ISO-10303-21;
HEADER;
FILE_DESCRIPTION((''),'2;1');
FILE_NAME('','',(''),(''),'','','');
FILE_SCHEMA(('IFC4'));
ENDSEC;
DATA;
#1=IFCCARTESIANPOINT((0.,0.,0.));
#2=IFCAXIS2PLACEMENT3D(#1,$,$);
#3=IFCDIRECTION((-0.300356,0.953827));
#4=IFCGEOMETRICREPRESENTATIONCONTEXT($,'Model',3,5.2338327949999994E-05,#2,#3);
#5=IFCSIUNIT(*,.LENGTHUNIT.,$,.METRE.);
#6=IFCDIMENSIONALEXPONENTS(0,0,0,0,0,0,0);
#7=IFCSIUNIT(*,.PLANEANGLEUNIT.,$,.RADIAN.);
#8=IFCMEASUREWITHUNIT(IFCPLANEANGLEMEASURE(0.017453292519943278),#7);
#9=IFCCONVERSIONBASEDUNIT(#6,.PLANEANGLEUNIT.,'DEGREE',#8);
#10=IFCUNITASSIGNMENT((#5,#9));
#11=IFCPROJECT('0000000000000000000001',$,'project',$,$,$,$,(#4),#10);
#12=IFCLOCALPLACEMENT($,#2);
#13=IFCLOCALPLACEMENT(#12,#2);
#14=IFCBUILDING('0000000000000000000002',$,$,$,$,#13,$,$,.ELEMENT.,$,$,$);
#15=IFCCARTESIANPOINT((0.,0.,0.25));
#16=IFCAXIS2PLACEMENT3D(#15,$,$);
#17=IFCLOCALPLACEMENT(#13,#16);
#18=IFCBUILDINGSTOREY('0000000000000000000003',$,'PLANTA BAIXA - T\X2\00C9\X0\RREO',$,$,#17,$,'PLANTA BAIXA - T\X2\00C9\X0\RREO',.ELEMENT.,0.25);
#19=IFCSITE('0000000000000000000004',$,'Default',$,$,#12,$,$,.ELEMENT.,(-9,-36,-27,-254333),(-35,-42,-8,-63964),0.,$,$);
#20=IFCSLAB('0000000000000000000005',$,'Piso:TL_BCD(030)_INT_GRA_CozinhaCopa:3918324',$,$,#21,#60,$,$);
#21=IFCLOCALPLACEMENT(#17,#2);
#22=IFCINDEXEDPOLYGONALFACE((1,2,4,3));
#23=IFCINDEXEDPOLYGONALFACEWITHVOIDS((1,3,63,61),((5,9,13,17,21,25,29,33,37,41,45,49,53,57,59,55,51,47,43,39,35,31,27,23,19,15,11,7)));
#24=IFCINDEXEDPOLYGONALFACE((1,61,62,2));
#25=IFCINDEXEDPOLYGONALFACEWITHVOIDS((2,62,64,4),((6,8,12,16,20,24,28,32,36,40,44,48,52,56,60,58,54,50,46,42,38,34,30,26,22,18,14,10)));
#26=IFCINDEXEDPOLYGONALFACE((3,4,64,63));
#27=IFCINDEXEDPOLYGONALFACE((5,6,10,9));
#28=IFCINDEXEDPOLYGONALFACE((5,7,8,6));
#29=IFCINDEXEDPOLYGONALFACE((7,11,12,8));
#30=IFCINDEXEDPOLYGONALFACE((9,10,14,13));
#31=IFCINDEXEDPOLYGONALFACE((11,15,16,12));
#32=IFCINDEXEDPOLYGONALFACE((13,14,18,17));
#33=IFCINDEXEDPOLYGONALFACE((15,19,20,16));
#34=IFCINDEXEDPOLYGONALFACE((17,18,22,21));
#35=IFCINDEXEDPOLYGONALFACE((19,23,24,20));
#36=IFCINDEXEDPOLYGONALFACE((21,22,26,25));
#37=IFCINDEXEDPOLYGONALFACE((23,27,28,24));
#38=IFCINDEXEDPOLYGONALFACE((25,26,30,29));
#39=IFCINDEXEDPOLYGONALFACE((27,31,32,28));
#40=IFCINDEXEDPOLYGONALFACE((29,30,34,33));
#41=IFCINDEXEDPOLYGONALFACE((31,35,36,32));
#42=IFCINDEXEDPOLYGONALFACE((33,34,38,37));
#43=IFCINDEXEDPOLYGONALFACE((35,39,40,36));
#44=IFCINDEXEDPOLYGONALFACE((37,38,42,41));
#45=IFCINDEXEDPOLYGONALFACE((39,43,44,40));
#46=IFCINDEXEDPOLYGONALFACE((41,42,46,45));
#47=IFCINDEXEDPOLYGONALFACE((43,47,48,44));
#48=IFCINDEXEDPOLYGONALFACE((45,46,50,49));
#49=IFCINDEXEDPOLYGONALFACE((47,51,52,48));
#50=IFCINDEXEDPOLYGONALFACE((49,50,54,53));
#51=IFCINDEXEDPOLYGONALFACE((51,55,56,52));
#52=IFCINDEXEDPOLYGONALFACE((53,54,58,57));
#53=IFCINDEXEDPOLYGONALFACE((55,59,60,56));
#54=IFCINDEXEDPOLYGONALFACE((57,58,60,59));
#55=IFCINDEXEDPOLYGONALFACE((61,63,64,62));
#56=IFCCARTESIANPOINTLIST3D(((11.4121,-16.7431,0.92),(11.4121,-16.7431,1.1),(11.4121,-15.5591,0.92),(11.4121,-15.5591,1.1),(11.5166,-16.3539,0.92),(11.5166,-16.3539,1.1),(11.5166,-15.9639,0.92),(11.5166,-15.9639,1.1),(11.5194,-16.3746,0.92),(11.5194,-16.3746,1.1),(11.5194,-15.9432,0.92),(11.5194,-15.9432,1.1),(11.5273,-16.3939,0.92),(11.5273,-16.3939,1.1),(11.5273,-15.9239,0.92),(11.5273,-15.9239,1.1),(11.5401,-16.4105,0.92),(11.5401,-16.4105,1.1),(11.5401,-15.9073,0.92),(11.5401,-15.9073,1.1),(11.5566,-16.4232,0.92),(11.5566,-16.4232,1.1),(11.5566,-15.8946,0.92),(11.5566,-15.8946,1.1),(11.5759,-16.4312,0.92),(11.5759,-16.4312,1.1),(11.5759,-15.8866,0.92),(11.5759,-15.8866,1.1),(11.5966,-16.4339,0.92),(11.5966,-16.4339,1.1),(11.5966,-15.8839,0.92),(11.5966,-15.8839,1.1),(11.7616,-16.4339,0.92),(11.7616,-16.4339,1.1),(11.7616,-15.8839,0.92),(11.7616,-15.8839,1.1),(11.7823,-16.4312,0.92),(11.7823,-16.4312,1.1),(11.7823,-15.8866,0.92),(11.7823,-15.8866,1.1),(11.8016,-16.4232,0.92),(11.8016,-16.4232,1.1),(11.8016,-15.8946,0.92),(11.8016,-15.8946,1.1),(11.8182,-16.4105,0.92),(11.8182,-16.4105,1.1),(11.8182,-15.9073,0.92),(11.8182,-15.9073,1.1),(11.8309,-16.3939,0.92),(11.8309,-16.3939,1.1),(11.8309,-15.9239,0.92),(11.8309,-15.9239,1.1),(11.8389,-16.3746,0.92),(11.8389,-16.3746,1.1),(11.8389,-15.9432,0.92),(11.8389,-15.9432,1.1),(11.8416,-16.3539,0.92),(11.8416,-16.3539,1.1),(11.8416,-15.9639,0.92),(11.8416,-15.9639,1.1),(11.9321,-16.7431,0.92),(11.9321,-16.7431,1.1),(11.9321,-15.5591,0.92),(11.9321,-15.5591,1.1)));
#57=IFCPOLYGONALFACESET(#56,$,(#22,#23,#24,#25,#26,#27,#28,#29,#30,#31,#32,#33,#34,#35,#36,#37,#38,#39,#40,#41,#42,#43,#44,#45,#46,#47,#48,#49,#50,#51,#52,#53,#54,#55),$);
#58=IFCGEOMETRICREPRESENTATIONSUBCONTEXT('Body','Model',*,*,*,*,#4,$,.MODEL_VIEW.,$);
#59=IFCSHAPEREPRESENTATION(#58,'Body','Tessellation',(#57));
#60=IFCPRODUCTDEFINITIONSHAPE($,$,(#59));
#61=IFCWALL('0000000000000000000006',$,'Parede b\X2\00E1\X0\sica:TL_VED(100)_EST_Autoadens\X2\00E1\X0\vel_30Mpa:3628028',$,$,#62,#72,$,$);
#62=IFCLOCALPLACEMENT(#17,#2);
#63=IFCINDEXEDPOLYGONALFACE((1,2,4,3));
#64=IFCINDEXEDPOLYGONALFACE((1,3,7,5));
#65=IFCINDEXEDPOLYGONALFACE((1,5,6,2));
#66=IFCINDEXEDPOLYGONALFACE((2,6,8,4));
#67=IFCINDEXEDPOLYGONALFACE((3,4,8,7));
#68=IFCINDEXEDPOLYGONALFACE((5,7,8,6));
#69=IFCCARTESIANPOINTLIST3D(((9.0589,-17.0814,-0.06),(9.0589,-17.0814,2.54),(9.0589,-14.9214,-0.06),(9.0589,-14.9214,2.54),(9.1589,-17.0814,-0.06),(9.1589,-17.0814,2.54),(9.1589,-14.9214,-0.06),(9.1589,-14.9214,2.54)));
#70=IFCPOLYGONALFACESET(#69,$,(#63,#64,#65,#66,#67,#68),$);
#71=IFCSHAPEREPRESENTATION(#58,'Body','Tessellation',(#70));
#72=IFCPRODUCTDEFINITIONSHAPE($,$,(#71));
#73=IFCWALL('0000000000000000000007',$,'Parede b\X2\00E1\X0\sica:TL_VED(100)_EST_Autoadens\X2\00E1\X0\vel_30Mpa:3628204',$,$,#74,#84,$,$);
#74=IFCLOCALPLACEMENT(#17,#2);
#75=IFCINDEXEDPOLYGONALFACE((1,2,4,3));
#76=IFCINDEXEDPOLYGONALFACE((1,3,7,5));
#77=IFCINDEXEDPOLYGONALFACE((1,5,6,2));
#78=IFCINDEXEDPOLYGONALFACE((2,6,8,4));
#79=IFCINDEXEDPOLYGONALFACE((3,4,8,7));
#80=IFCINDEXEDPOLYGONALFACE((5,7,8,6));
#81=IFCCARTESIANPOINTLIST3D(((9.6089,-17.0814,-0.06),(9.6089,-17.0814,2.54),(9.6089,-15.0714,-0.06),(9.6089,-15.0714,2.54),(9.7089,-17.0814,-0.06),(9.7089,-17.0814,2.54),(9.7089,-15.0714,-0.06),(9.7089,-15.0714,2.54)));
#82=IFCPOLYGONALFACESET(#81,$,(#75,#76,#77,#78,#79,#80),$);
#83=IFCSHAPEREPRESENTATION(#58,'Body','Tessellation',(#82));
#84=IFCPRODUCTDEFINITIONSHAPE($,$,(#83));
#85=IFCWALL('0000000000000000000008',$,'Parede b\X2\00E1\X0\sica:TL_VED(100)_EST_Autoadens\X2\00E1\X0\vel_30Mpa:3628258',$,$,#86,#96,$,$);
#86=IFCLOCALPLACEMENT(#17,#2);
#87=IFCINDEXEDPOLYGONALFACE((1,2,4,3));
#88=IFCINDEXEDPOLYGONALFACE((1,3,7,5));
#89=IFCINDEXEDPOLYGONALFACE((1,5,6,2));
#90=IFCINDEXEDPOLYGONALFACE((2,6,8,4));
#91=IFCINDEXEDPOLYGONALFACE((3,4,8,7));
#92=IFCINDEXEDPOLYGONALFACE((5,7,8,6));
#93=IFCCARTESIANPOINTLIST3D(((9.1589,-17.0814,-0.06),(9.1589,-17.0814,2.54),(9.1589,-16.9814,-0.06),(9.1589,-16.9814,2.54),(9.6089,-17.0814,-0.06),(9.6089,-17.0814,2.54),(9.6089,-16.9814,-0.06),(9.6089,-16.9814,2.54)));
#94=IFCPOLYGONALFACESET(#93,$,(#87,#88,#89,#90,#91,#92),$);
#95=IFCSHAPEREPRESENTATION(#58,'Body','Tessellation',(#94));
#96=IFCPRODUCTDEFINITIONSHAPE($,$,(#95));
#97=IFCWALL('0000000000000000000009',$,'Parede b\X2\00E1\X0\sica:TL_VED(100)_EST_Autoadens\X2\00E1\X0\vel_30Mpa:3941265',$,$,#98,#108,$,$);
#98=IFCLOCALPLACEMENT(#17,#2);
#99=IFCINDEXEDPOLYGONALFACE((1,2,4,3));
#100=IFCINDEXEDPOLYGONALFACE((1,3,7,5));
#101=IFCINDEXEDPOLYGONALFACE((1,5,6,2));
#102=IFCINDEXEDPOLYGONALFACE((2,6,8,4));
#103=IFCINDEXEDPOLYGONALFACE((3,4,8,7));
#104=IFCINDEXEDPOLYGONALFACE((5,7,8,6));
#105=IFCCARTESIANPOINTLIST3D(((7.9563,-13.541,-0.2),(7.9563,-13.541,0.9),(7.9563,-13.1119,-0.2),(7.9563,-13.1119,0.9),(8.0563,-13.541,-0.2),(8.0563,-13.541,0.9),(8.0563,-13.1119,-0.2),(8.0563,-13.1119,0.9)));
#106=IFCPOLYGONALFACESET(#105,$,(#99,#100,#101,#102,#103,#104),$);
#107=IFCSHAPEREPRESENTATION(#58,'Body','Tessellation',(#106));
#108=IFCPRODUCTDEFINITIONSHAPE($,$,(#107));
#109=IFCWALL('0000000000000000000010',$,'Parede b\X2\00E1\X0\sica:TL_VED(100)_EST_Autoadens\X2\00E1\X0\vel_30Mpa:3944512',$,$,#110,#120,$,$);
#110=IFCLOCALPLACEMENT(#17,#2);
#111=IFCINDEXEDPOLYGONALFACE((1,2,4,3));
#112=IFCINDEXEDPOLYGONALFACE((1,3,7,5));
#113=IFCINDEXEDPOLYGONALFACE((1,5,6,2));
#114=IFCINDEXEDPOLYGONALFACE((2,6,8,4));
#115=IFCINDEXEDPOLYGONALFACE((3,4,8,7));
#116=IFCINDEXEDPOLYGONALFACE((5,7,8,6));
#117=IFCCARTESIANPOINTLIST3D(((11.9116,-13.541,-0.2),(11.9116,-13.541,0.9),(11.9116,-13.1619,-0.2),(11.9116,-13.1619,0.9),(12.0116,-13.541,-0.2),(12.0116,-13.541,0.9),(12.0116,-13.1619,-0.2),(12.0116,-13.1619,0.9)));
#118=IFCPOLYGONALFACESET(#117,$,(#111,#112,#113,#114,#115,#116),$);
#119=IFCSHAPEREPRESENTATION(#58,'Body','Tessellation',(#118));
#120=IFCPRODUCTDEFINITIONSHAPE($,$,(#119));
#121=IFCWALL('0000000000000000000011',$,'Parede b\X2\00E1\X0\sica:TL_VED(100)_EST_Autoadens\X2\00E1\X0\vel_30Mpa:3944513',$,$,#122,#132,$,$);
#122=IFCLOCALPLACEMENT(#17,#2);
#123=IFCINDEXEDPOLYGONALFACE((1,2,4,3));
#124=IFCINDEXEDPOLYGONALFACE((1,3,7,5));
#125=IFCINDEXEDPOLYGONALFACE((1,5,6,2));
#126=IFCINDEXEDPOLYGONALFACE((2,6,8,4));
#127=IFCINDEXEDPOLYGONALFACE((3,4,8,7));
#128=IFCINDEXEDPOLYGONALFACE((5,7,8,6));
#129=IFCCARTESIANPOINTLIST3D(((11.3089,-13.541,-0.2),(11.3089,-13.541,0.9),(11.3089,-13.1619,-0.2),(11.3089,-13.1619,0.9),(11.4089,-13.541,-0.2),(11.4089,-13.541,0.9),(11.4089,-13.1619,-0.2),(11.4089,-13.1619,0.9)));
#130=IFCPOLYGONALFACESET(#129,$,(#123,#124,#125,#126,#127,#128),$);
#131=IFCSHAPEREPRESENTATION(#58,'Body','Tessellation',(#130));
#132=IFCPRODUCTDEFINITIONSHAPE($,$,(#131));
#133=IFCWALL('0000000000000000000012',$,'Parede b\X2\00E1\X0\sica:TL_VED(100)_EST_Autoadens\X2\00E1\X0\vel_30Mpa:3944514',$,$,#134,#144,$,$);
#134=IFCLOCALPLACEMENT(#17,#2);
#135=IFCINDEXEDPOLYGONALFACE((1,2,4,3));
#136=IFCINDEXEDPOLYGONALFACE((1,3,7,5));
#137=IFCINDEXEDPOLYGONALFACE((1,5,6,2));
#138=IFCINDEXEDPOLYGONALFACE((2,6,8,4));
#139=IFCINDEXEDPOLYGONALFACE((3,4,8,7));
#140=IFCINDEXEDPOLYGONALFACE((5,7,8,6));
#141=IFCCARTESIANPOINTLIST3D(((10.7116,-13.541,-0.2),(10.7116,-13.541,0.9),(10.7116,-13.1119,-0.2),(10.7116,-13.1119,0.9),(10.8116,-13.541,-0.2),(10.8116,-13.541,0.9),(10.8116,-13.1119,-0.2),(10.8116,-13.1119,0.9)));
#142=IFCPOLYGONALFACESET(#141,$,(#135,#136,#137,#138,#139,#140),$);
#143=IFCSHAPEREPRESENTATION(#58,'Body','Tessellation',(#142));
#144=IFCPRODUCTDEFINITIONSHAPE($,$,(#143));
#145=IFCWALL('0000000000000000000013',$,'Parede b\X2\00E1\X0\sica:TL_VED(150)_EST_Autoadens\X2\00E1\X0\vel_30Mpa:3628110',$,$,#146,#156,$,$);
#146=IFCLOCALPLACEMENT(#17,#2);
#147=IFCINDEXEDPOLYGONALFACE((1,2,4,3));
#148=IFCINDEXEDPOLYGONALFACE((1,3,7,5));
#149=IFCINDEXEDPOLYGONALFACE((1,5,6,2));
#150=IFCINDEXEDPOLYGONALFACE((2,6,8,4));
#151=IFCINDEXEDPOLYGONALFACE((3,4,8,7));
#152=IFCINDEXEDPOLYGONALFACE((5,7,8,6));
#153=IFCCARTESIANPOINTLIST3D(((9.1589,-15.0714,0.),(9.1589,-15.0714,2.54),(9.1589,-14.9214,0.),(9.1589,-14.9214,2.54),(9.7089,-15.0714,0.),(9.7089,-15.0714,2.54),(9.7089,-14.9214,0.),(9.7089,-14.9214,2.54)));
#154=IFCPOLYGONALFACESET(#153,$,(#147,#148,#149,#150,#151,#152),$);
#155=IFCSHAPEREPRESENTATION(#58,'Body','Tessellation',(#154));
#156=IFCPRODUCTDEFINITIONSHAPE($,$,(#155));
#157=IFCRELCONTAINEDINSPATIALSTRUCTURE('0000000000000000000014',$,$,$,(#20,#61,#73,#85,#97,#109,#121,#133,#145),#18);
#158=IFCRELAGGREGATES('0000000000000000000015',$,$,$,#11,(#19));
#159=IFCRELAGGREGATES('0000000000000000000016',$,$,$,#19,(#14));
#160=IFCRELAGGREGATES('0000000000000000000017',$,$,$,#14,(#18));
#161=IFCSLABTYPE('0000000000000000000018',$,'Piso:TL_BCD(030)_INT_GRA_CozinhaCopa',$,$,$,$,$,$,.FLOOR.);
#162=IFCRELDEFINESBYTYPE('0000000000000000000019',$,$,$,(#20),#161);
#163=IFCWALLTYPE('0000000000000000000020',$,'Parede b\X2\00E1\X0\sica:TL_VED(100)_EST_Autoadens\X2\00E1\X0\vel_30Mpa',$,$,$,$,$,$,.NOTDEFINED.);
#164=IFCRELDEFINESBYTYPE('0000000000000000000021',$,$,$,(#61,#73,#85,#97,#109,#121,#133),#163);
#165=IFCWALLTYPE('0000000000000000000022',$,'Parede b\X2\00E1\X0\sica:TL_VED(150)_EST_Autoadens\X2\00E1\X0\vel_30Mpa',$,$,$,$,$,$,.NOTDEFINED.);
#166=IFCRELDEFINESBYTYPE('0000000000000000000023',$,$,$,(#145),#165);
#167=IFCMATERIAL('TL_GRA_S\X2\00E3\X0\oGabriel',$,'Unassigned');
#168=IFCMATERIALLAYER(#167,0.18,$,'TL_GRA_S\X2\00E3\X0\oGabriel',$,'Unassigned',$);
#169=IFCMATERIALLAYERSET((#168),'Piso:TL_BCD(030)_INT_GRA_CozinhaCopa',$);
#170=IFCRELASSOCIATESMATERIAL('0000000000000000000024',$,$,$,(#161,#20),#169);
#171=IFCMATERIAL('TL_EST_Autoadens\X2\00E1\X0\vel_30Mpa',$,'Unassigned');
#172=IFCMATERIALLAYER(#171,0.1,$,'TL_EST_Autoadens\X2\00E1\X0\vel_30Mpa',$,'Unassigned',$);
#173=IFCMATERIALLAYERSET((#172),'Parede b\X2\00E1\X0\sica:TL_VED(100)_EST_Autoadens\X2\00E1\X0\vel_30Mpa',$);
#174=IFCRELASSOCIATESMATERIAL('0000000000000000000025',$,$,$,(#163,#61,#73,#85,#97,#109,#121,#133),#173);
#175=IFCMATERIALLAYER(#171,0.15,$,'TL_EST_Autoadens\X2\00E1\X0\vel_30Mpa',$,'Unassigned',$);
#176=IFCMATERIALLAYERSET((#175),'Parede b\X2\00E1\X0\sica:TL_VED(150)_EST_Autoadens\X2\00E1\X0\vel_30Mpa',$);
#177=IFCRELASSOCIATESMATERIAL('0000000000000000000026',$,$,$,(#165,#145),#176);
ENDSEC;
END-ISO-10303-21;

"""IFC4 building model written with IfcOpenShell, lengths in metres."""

from ifc_helpers import new_model, entity, si_unit, converted_unit, direction, frame, frame_2d, origin, place, context, subcontext, project, spatial, polyline, circle_curve, parameter, trimmed, segment, composite_curve, rectangle, outline, extrude, clip, bounded_halfspace, material, layer, layer_set, layer_usage, type_object, element, save


model = new_model("IFC4")

# Units and contexts
model_context = context("Model", 3, precision=5.2338327949999994e-05, world=origin(), true_north=direction((-0.300356, 0.953827)))
body_context = subcontext(model_context, "Body", "Model", "MODEL_VIEW")
ifc_project = project(units=[si_unit("LENGTHUNIT", "METRE"), converted_unit("PLANEANGLEUNIT", "DEGREE", entity("IfcPlaneAngleMeasure", 0.017453292519943278), si_unit("PLANEANGLEUNIT", "RADIAN"), dimensions=[0, 0, 0, 0, 0, 0, 0])], contexts=[model_context])

# Site, building, storey
site_placement = place(None, origin())
site = spatial("IfcSite", under=ifc_project, at=site_placement, Name="Default", CompositionType="ELEMENT", RefLatitude=(-9, -36, -27, -254333), RefLongitude=(-35, -42, -8, -63964), RefElevation=0.0)
building_placement = place(site_placement, origin())
building = spatial("IfcBuilding", under=site, at=building_placement, CompositionType="ELEMENT")
storey_placement = place(building_placement, frame((0.0, 0.0, 0.25)))
storey = spatial("IfcBuildingStorey", under=building, at=storey_placement, Name="PLANTA BAIXA - TÉRREO", LongName="PLANTA BAIXA - TÉRREO", CompositionType="ELEMENT", Elevation=0.25)

# Slab, opening
ifc_material_1 = material(Name="TL_GRA_SãoGabriel", Category="Unassigned")
ifc_layer_1 = layer(ifc_material_1, 0.18, Name="TL_GRA_SãoGabriel", Category="Unassigned")
ifc_layer_set_1 = layer_set([ifc_layer_1], Name="Piso:TL_BCD(030)_INT_GRA_CozinhaCopa")
ifc_layer_usage_1 = layer_usage(ifc_layer_set_1, "AXIS3", "POSITIVE", 0.0)
slab_type_1 = type_object("IfcSlabType", Name="Piso:TL_BCD(030)_INT_GRA_CozinhaCopa", PredefinedType="FLOOR", material=ifc_layer_set_1)
slab_1_placement = place(storey_placement, frame((11.4121, -16.7431, 0.92)))
slab_1 = element("IfcSlab", 1, at=slab_1_placement, inside=storey, type_object=slab_type_1, material=ifc_layer_usage_1, Name="Piso:TL_BCD(030)_INT_GRA_CozinhaCopa:3918324", context=body_context, shape_type="SweptSolid", body=[
    extrude(rectangle(XDim=0.52, YDim=1.184, at=frame_2d((0.0, 0.0), x_axis=(-1.0, 0.0))), frame((0.26, 0.592, 0.18), z_axis=(0.0, 0.0, -1.0), x_axis=(-1.0, 0.0, 0.0)), (0.0, 0.0, 1.0), 0.18),
])
opening_1_placement = place(slab_1_placement, frame((-11.4121, 16.7431, 0.18)))
element("IfcOpeningElement", 2, at=opening_1_placement, cuts=slab_1, PredefinedType="OPENING", context=body_context, shape_type="SweptSolid", body=[
    extrude(outline(composite_curve([segment(trimmed(circle_curve(frame_2d((0.195, -0.0825), x_axis=(1.0, 0.0)), 0.08), [parameter(270.0)], [parameter(0.0)], True, "PARAMETER"), True, "CONTINUOUS"), segment(polyline([(0.275, -0.0825), (0.275, 0.0825)]), True, "CONTINUOUS"), segment(trimmed(circle_curve(frame_2d((0.195, 0.0825), x_axis=(1.0, 0.0)), 0.08), [parameter(0.0)], [parameter(90.0)], True, "PARAMETER"), True, "CONTINUOUS"), segment(polyline([(0.195, 0.1625), (-0.195, 0.1625)]), True, "CONTINUOUS"), segment(trimmed(circle_curve(frame_2d((-0.195, 0.0825), x_axis=(1.0, 0.0)), 0.08), [parameter(90.0)], [parameter(180.0)], True, "PARAMETER"), True, "CONTINUOUS"), segment(polyline([(-0.275, 0.0825), (-0.275, -0.0825)]), True, "CONTINUOUS"), segment(trimmed(circle_curve(frame_2d((-0.195, -0.0825), x_axis=(1.0, 0.0)), 0.08), [parameter(180.0)], [parameter(270.0)], True, "PARAMETER"), True, "CONTINUOUS"), segment(polyline([(-0.195, -0.1625), (0.195, -0.1625)]), True, "CONTINUOUS")], self_intersect=False)), frame((11.6791, -16.1589, -0.21), z_axis=(0.0, 0.0, 1.0), x_axis=(0.0, -1.0, 0.0)), (0.0, 0.0, 1.0), 0.21),
])

# Walls
ifc_material_2 = material(Name="TL_EST_Autoadensável_30Mpa", Category="Unassigned")
ifc_layer_2 = layer(ifc_material_2, 0.1, Name="TL_EST_Autoadensável_30Mpa", Category="Unassigned")
ifc_layer_set_2 = layer_set([ifc_layer_2], Name="Parede básica:TL_VED(100)_EST_Autoadensável_30Mpa")
ifc_layer_usage_2 = layer_usage(ifc_layer_set_2, "AXIS2", "NEGATIVE", 0.05)
wall_type_1 = type_object("IfcWallType", Name="Parede básica:TL_VED(100)_EST_Autoadensável_30Mpa", PredefinedType="NOTDEFINED", material=ifc_layer_set_2)
wall_1_placement = place(storey_placement, frame((9.1089, -17.0814, -0.06), z_axis=(0.0, 0.0, 1.0), x_axis=(0.0, 1.0, 0.0)))
element("IfcWall", 3, at=wall_1_placement, inside=storey, type_object=wall_type_1, material=ifc_layer_usage_2, Name="Parede básica:TL_VED(100)_EST_Autoadensável_30Mpa:3628028", context=body_context, shape_type="SweptSolid", body=[
    extrude(rectangle(XDim=2.16, YDim=0.1, at=frame_2d((1.08, 0.0), x_axis=(-1.0, 0.0))), origin(), (0.0, 0.0, 1.0), 2.6),
])
ifc_layer_usage_3 = layer_usage(ifc_layer_set_2, "AXIS2", "NEGATIVE", 0.05)
wall_2_placement = place(storey_placement, frame((9.6589, -15.0714, -0.06), z_axis=(0.0, 0.0, 1.0), x_axis=(0.0, -1.0, 0.0)))
element("IfcWall", 4, at=wall_2_placement, inside=storey, type_object=wall_type_1, material=ifc_layer_usage_3, Name="Parede básica:TL_VED(100)_EST_Autoadensável_30Mpa:3628204", context=body_context, shape_type="SweptSolid", body=[
    extrude(rectangle(XDim=2.01, YDim=0.1, at=frame_2d((1.005, 0.0), x_axis=(-1.0, 0.0))), origin(), (0.0, 0.0, 1.0), 2.6),
])
ifc_layer_usage_4 = layer_usage(ifc_layer_set_2, "AXIS2", "NEGATIVE", 0.05)
wall_3_placement = place(storey_placement, frame((9.6089, -17.0314, -0.06), z_axis=(0.0, 0.0, 1.0), x_axis=(-1.0, 0.0, 0.0)))
element("IfcWall", 5, at=wall_3_placement, inside=storey, type_object=wall_type_1, material=ifc_layer_usage_4, Name="Parede básica:TL_VED(100)_EST_Autoadensável_30Mpa:3628258", context=body_context, shape_type="SweptSolid", body=[
    extrude(rectangle(XDim=0.45, YDim=0.1, at=frame_2d((0.225, 0.0), x_axis=(-1.0, 0.0))), origin(), (0.0, 0.0, 1.0), 2.6),
])
ifc_layer_usage_5 = layer_usage(ifc_layer_set_2, "AXIS2", "NEGATIVE", 0.05)
wall_4_placement = place(storey_placement, frame((8.0063, -13.1119, -0.2), z_axis=(0.0, 0.0, 1.0), x_axis=(0.0, -1.0, 0.0)))
element("IfcWall", 6, at=wall_4_placement, inside=storey, type_object=wall_type_1, material=ifc_layer_usage_5, Name="Parede básica:TL_VED(100)_EST_Autoadensável_30Mpa:3941265", context=body_context, shape_type="Clipping", body=[
    clip(extrude(rectangle(XDim=0.4291, YDim=0.1, at=frame_2d((0.2145, 0.0), x_axis=(-1.0, 0.0))), origin(), (0.0, 0.0, 1.0), 1.1), bounded_halfspace(frame((0.0, -0.05, 1.1), z_axis=(0.0, 0.0, -1.0), x_axis=(1.0, 0.0, 0.0)), True, frame((0.0, -0.05, 1.1)), polyline([(0.0, 0.0), (0.05, 0.0), (0.4291, 0.0), (0.4291, 0.1), (0.0, 0.1), (0.0, 0.0)]))),
])
ifc_layer_usage_6 = layer_usage(ifc_layer_set_2, "AXIS2", "POSITIVE", -0.05)
wall_5_placement = place(storey_placement, frame((11.9616, -13.1619, -0.2), z_axis=(0.0, 0.0, 1.0), x_axis=(0.0, -1.0, 0.0)))
element("IfcWall", 7, at=wall_5_placement, inside=storey, type_object=wall_type_1, material=ifc_layer_usage_6, Name="Parede básica:TL_VED(100)_EST_Autoadensável_30Mpa:3944512", context=body_context, shape_type="Clipping", body=[
    clip(extrude(rectangle(XDim=0.3791, YDim=0.1, at=frame_2d((0.1895, 0.0), x_axis=(-1.0, 0.0))), origin(), (0.0, 0.0, 1.0), 1.1), bounded_halfspace(frame((0.0, -0.05, 1.1), z_axis=(0.0, 0.0, -1.0), x_axis=(0.0, 1.0, 0.0)), True, frame((0.0, -0.05, 1.1)), polyline([(0.0, 0.0), (0.3791, 0.0), (0.3791, 0.1), (0.0, 0.1), (0.0, 0.0)]))),
])
ifc_layer_usage_7 = layer_usage(ifc_layer_set_2, "AXIS2", "POSITIVE", -0.05)
wall_6_placement = place(storey_placement, frame((11.3589, -13.1619, -0.2), z_axis=(0.0, 0.0, 1.0), x_axis=(0.0, -1.0, 0.0)))
element("IfcWall", 8, at=wall_6_placement, inside=storey, type_object=wall_type_1, material=ifc_layer_usage_7, Name="Parede básica:TL_VED(100)_EST_Autoadensável_30Mpa:3944513", context=body_context, shape_type="Clipping", body=[
    clip(extrude(rectangle(XDim=0.3791, YDim=0.1, at=frame_2d((0.1895, 0.0), x_axis=(-1.0, 0.0))), origin(), (0.0, 0.0, 1.0), 1.1), bounded_halfspace(frame((0.0, -0.05, 1.1), z_axis=(0.0, 0.0, -1.0), x_axis=(0.0, 1.0, 0.0)), True, frame((0.0, -0.05, 1.1)), polyline([(0.0, 0.0), (0.3791, 0.0), (0.3791, 0.1), (0.0, 0.1), (0.0, 0.0)]))),
])
ifc_layer_usage_8 = layer_usage(ifc_layer_set_2, "AXIS2", "POSITIVE", -0.05)
wall_7_placement = place(storey_placement, frame((10.7616, -13.1119, -0.2), z_axis=(0.0, 0.0, 1.0), x_axis=(0.0, -1.0, 0.0)))
element("IfcWall", 9, at=wall_7_placement, inside=storey, type_object=wall_type_1, material=ifc_layer_usage_8, Name="Parede básica:TL_VED(100)_EST_Autoadensável_30Mpa:3944514", context=body_context, shape_type="Clipping", body=[
    clip(extrude(rectangle(XDim=0.4291, YDim=0.1, at=frame_2d((0.2145, 0.0), x_axis=(-1.0, 0.0))), origin(), (0.0, 0.0, 1.0), 1.1), bounded_halfspace(frame((0.0, -0.05, 1.1), z_axis=(0.0, 0.0, -1.0), x_axis=(0.0, 1.0, 0.0)), True, frame((0.0, -0.05, 1.1)), polyline([(0.0, 0.0), (0.4291, 0.0), (0.4291, 0.1), (0.05, 0.1), (0.0, 0.1), (0.0, 0.0)]))),
])
ifc_layer_3 = layer(ifc_material_2, 0.15, Name="TL_EST_Autoadensável_30Mpa", Category="Unassigned")
ifc_layer_set_3 = layer_set([ifc_layer_3], Name="Parede básica:TL_VED(150)_EST_Autoadensável_30Mpa")
ifc_layer_usage_9 = layer_usage(ifc_layer_set_3, "AXIS2", "NEGATIVE", 0.075)
wall_type_2 = type_object("IfcWallType", Name="Parede básica:TL_VED(150)_EST_Autoadensável_30Mpa", PredefinedType="NOTDEFINED", material=ifc_layer_set_3)
wall_8_placement = place(storey_placement, frame((9.1589, -14.9964, 0.0)))
element("IfcWall", 10, at=wall_8_placement, inside=storey, type_object=wall_type_2, material=ifc_layer_usage_9, Name="Parede básica:TL_VED(150)_EST_Autoadensável_30Mpa:3628110", context=body_context, shape_type="SweptSolid", body=[
    extrude(rectangle(XDim=0.55, YDim=0.15, at=frame_2d((0.275, 0.0), x_axis=(-1.0, 0.0))), origin(), (0.0, 0.0, 1.0), 2.54),
])

save(model, "model.ifc")
